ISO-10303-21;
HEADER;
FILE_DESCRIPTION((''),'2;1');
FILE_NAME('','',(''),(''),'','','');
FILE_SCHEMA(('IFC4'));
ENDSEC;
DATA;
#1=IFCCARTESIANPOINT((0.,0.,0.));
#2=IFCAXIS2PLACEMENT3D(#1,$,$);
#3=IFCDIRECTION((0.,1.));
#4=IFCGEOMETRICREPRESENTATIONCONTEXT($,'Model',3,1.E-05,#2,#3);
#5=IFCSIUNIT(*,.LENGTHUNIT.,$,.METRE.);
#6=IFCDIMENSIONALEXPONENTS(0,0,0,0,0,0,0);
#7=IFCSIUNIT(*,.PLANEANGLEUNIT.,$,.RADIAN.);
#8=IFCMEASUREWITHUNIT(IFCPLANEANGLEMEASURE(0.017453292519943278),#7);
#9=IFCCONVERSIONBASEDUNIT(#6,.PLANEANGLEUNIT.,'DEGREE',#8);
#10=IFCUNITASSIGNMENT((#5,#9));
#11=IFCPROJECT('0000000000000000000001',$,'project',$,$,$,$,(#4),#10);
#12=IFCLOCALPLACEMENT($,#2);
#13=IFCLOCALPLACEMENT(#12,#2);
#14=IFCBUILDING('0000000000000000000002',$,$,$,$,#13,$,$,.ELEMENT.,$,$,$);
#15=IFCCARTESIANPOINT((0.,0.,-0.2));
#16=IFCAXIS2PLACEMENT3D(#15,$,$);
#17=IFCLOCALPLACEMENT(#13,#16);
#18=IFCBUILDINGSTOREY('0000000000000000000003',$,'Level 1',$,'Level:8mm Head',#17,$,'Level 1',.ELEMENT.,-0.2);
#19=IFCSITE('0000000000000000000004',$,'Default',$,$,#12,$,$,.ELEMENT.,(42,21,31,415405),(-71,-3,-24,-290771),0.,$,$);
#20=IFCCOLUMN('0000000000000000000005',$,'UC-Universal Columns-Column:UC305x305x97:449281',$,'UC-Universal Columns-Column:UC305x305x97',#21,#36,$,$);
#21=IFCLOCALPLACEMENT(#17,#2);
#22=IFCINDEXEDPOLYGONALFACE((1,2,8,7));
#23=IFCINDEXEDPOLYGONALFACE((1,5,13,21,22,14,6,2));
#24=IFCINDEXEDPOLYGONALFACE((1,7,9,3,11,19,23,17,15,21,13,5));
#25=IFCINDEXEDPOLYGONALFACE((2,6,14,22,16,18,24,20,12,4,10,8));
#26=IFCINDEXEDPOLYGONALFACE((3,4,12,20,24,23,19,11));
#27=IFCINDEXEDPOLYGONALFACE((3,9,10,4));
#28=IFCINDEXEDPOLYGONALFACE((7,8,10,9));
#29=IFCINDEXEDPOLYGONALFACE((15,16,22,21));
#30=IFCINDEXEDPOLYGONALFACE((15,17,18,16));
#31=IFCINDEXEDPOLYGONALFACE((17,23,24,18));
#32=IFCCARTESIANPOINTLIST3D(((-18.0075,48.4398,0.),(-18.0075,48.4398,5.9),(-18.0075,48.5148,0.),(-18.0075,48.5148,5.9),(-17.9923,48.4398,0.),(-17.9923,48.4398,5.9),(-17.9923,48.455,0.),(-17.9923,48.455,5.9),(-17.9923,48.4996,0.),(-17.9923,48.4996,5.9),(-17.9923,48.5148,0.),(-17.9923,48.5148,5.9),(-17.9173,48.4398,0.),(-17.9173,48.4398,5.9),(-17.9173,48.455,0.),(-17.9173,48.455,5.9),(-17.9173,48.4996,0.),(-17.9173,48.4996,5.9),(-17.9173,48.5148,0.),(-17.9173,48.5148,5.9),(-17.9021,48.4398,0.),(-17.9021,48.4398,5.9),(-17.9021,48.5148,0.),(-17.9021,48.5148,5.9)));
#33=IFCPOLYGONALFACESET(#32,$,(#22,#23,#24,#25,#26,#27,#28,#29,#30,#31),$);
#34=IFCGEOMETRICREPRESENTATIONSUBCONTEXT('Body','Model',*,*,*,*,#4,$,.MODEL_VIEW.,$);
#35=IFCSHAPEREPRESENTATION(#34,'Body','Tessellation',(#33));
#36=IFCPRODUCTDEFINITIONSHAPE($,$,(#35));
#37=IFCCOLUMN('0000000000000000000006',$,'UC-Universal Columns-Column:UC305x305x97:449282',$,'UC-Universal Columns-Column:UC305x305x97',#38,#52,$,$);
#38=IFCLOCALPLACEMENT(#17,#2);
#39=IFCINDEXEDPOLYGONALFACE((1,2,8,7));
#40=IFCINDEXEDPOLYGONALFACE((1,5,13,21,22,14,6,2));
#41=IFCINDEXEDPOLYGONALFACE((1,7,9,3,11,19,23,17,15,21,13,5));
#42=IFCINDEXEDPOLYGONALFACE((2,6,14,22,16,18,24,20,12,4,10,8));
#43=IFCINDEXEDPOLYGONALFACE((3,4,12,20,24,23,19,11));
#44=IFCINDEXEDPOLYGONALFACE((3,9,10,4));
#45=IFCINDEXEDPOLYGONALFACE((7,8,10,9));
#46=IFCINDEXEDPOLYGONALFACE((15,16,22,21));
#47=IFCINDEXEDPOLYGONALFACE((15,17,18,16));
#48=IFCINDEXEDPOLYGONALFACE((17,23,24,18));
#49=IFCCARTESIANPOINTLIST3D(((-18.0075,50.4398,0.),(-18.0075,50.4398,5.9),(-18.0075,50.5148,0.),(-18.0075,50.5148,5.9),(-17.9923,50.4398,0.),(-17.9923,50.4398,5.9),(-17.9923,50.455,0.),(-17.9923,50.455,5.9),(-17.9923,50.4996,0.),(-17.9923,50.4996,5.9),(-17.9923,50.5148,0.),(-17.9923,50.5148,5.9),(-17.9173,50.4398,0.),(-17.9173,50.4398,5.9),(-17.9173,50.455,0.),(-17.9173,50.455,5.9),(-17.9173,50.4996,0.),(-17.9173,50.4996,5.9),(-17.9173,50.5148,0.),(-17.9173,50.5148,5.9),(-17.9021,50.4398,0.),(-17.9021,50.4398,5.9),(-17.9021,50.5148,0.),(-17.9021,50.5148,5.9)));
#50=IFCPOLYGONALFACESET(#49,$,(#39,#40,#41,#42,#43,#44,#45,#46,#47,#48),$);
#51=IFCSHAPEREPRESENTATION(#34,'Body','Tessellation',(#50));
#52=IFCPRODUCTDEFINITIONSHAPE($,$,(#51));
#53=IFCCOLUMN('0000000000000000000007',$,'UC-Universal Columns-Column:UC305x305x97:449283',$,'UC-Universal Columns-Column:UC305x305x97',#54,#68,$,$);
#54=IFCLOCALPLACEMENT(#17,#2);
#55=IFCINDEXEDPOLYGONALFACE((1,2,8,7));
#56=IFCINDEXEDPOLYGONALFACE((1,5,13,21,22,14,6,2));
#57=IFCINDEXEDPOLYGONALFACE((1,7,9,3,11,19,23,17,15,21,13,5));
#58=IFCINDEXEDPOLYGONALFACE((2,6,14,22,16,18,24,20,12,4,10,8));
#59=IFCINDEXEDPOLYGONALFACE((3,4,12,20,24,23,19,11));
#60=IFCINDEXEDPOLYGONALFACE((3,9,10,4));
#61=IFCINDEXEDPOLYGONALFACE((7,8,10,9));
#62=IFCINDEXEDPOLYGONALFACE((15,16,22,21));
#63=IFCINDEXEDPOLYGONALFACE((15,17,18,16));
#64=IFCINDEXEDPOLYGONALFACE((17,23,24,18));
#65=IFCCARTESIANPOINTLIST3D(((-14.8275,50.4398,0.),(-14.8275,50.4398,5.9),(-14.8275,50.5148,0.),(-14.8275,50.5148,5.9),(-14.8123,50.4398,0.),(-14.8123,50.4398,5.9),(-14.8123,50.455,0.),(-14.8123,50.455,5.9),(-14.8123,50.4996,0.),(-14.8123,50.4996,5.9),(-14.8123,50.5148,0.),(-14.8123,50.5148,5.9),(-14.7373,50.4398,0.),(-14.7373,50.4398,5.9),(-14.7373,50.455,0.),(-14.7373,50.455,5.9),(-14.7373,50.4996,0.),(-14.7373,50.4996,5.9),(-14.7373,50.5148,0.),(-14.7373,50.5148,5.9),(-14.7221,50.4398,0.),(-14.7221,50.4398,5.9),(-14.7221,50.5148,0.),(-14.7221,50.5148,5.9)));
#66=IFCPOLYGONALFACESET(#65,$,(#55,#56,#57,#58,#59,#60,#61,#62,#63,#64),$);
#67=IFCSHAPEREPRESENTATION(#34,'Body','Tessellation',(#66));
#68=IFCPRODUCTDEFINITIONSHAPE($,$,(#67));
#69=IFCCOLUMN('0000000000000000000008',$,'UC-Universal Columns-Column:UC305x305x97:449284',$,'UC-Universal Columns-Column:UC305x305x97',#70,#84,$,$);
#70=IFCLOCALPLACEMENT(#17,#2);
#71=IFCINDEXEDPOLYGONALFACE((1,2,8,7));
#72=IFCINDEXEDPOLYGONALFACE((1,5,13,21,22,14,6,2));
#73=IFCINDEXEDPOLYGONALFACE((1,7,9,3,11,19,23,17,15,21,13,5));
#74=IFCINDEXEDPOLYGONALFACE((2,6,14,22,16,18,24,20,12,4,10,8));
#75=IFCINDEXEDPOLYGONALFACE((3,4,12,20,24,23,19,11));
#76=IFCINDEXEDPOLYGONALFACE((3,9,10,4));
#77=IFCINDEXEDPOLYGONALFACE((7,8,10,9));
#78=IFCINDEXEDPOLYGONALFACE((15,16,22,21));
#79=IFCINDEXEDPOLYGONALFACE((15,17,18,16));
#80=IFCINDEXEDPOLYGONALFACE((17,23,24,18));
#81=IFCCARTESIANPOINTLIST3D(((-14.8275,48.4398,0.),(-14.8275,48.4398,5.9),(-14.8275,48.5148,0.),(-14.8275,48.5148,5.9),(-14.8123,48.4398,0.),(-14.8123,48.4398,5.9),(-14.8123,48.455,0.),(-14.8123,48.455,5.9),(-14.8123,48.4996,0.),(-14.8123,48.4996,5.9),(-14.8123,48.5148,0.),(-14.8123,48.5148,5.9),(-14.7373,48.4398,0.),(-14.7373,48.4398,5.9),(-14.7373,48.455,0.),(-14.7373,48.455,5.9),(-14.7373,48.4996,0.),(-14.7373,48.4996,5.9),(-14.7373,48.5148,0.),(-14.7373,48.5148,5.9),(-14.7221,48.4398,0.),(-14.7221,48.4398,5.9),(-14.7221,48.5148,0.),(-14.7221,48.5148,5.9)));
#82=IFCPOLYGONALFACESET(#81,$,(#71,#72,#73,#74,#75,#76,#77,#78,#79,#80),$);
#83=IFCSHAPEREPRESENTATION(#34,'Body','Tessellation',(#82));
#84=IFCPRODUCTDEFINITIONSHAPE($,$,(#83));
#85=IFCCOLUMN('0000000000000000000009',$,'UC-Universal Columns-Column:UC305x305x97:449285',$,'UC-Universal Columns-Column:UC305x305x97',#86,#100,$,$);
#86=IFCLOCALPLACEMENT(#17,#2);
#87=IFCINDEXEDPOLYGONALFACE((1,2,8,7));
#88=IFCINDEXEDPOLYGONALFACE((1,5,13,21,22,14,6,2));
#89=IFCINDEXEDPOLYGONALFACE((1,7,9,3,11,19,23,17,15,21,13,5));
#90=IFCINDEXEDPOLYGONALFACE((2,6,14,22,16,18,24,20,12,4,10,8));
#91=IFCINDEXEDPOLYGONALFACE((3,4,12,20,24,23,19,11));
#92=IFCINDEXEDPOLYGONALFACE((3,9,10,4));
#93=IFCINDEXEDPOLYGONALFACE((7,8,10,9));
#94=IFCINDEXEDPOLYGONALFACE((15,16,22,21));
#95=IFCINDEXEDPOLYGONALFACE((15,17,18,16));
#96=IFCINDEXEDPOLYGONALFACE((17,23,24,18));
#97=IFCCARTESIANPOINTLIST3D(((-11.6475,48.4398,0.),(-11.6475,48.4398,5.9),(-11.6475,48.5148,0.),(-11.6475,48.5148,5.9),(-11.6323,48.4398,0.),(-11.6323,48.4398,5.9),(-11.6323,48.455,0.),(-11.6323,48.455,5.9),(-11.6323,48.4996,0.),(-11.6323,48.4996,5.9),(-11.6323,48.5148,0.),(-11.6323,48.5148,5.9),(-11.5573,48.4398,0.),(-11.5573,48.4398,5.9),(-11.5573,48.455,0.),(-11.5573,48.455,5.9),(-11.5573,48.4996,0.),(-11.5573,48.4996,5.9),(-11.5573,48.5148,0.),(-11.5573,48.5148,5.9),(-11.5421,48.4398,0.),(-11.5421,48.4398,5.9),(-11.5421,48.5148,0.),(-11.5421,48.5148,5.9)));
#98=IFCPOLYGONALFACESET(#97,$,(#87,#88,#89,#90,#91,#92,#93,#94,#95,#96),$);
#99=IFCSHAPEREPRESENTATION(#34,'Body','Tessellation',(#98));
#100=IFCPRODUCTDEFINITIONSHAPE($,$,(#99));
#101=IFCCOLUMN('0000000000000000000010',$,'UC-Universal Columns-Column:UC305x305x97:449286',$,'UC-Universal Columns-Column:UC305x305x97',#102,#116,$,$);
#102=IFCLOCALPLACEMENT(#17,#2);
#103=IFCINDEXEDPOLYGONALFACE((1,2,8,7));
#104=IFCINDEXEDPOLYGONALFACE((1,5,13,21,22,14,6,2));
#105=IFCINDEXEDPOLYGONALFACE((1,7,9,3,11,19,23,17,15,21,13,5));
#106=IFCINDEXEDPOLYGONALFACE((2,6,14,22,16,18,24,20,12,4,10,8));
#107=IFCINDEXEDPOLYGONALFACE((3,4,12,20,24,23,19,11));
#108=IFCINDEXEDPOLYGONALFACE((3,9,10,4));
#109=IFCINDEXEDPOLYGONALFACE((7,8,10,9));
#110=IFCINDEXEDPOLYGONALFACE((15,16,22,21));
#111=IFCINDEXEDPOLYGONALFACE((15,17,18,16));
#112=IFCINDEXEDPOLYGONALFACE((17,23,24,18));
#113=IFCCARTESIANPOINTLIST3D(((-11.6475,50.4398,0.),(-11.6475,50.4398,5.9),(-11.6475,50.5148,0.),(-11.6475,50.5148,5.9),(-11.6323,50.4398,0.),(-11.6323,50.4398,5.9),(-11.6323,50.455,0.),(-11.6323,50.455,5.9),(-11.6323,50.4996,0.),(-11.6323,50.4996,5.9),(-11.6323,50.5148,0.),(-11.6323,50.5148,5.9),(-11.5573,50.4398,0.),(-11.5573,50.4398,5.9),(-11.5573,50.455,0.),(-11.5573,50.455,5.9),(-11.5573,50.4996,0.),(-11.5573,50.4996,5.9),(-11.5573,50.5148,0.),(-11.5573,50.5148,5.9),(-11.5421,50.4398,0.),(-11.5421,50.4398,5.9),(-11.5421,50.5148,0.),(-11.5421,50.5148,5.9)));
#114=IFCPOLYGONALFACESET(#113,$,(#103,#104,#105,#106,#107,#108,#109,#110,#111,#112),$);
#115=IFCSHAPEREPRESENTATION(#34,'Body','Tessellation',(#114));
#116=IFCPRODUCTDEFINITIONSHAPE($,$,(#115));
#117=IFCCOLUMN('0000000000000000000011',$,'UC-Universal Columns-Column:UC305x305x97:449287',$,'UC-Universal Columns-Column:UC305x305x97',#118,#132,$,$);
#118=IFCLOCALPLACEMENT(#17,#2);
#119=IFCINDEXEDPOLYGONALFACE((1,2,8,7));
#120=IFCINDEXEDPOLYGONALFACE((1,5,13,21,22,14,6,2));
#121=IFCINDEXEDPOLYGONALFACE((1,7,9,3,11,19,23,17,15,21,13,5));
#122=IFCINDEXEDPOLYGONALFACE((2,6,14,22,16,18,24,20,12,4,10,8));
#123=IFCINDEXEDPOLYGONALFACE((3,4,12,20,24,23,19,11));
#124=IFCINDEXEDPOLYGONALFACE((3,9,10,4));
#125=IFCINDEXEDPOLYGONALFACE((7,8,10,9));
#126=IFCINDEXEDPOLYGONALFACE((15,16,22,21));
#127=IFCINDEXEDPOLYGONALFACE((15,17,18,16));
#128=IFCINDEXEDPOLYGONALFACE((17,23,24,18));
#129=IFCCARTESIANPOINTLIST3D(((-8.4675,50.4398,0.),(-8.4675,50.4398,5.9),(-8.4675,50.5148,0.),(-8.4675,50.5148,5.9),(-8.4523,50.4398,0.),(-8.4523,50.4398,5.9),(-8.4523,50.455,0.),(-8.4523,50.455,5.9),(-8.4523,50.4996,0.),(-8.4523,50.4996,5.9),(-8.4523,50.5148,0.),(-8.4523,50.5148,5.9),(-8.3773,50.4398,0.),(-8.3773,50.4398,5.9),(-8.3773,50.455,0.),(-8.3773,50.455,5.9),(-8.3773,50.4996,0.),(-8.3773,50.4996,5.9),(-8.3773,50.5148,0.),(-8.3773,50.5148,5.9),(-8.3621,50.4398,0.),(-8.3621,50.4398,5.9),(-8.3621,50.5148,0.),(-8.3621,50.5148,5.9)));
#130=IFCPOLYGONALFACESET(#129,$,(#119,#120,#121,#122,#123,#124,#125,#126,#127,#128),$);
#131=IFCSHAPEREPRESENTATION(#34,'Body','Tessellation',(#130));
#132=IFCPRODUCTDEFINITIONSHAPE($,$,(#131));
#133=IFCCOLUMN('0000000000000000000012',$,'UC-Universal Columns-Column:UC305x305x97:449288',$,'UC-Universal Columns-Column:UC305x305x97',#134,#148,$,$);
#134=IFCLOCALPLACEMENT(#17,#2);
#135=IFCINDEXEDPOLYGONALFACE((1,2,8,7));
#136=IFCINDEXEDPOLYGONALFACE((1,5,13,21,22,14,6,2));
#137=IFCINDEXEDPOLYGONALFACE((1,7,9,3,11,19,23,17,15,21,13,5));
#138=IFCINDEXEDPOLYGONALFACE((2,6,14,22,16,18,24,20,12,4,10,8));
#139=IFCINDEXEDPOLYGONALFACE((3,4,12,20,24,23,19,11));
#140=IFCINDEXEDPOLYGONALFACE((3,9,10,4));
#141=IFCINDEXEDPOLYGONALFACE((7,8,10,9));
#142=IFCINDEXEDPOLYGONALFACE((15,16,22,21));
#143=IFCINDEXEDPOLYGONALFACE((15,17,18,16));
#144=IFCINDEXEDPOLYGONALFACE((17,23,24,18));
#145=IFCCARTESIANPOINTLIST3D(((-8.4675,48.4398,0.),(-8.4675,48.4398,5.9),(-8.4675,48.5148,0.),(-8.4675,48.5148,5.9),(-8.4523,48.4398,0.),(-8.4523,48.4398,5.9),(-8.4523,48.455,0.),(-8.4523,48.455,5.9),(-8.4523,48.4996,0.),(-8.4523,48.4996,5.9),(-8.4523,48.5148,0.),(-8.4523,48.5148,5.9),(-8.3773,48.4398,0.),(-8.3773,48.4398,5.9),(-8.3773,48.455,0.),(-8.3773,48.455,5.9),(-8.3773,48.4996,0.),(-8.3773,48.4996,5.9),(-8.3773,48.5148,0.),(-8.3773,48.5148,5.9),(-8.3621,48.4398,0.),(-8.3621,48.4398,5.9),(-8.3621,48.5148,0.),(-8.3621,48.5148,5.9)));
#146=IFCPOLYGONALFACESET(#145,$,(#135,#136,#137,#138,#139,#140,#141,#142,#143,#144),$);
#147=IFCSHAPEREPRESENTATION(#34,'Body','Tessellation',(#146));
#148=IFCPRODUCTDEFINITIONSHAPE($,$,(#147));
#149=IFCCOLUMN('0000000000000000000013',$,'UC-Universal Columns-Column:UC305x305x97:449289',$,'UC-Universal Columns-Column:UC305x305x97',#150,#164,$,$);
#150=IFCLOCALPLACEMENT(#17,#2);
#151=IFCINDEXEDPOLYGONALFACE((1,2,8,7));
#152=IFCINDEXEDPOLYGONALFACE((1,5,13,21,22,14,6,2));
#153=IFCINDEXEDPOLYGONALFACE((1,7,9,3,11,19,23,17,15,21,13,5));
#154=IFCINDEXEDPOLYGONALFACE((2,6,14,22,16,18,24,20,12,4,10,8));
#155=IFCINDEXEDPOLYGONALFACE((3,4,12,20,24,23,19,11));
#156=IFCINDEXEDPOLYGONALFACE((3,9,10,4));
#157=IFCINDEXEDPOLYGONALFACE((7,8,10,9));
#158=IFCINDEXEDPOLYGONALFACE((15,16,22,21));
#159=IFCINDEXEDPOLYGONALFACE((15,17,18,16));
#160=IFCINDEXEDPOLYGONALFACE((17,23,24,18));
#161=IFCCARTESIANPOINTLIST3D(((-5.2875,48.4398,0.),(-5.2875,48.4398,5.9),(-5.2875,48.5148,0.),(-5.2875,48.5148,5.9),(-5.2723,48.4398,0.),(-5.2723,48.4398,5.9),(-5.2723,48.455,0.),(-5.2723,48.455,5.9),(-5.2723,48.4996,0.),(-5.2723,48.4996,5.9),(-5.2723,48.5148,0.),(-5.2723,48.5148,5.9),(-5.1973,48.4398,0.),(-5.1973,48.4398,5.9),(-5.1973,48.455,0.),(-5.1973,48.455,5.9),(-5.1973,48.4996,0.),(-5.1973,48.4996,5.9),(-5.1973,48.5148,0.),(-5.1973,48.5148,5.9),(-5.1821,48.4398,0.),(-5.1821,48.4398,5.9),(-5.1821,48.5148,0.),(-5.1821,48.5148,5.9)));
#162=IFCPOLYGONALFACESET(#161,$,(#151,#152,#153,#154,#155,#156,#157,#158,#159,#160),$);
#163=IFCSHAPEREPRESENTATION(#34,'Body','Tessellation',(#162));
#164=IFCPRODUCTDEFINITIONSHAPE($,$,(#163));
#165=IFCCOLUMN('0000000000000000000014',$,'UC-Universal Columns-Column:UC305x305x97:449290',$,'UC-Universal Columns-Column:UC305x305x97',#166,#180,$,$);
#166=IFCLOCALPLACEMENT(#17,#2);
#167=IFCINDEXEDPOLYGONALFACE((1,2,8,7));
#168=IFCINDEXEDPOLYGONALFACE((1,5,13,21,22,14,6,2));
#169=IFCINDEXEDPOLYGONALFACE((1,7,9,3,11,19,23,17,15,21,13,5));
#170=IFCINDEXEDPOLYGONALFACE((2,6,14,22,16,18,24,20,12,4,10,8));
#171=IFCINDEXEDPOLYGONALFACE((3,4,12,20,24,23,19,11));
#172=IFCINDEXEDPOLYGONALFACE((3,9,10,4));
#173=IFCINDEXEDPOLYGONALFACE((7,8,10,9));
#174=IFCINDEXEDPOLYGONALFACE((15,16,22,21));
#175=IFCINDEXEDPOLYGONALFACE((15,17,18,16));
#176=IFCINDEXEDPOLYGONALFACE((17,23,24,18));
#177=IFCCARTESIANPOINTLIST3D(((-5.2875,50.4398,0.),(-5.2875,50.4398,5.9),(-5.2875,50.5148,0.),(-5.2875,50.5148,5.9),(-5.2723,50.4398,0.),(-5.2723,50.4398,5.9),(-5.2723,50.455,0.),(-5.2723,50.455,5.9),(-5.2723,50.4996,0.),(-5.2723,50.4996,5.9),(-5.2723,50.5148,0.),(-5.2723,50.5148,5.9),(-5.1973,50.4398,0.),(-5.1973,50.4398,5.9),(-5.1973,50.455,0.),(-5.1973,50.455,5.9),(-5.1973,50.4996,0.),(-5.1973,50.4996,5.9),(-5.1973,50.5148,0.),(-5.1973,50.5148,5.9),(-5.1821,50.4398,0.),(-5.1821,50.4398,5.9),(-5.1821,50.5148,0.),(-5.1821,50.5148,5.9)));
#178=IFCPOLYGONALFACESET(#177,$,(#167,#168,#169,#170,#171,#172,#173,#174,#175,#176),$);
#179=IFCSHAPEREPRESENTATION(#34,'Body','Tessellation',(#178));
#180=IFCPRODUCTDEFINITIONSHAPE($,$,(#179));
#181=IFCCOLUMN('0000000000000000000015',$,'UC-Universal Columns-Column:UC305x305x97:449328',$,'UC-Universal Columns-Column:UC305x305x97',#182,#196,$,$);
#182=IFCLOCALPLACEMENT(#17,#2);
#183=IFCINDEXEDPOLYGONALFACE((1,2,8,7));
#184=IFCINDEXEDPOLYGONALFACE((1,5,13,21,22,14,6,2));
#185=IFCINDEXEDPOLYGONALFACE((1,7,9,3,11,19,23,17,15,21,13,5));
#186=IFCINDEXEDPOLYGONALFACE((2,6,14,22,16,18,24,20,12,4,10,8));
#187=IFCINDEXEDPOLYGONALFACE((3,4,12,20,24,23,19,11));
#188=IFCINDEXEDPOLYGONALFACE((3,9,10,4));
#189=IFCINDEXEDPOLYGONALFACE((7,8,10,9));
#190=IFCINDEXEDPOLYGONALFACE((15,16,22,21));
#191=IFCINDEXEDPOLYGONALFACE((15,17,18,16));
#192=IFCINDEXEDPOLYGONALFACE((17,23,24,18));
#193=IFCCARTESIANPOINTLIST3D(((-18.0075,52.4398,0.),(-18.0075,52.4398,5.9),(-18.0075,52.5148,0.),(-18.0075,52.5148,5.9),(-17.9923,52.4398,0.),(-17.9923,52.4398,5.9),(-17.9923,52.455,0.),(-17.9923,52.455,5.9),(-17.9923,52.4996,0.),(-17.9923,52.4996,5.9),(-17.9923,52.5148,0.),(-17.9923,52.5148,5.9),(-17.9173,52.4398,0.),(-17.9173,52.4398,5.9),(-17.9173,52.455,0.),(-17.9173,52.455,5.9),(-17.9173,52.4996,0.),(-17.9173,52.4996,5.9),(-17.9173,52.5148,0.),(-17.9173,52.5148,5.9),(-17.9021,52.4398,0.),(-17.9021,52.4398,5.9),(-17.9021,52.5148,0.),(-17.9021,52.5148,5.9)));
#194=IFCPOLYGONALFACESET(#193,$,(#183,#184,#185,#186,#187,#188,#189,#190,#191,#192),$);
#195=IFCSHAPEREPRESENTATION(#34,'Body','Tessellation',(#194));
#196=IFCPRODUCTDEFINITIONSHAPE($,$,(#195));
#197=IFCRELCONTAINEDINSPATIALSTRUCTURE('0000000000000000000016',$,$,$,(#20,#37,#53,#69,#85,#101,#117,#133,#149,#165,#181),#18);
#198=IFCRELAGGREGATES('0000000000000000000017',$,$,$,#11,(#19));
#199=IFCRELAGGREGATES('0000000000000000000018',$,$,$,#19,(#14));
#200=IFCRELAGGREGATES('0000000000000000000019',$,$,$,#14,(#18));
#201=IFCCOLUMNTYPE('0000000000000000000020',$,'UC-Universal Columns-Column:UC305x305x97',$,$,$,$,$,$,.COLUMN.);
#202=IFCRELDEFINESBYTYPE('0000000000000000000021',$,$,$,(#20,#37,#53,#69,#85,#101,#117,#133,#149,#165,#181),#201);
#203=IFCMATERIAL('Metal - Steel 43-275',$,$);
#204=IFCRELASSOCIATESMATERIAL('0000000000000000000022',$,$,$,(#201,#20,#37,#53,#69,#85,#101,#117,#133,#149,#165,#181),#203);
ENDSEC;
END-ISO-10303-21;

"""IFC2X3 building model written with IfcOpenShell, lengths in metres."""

from ifc_helpers import new_model, entity, si_unit, converted_unit, direction, frame, frame_2d, origin, place, context, subcontext, project, spatial, polyline, circle_curve, parameter, trimmed, segment, composite_curve, outline, extrude, source, transform, mapped, material, type_object, type_shapes, element, save


model = new_model("IFC2X3")

# Units and contexts
model_context = context("Model", 3, precision=1e-05, world=origin(), true_north=direction((0.0, 1.0)))
body_context = subcontext(model_context, "Body", "Model", "MODEL_VIEW")
ifc_project = project(units=[si_unit("LENGTHUNIT", "METRE"), converted_unit("PLANEANGLEUNIT", "DEGREE", entity("IfcPlaneAngleMeasure", 0.017453292519943278), si_unit("PLANEANGLEUNIT", "RADIAN"), dimensions=[0, 0, 0, 0, 0, 0, 0])], contexts=[model_context])

# Site, building, storey
site_placement = place(None, origin())
site = spatial("IfcSite", under=ifc_project, at=site_placement, Name="Default", CompositionType="ELEMENT", RefLatitude=(42, 21, 31, 415405), RefLongitude=(-71, -3, -24, -290771), RefElevation=0.0)
building_placement = place(site_placement, origin())
building = spatial("IfcBuilding", under=site, at=building_placement, CompositionType="ELEMENT")
storey_placement = place(building_placement, frame((0.0, 0.0, -0.2)))
storey = spatial("IfcBuildingStorey", under=building, at=storey_placement, Name="Level 1", ObjectType="Level:8mm Head", LongName="Level 1", CompositionType="ELEMENT", Elevation=-0.2)

# Columns
ifc_material = material(Name="Metal - Steel 43-275")
column_type = type_object("IfcColumnType", Name="UC-Universal Columns-Column:UC305x305x97", PredefinedType="COLUMN", material=ifc_material)
shared_shape = source(origin(), body_context, "Body", "SweptSolid", [
    extrude(outline(composite_curve([segment(polyline([(-0.0375, -0.0375), (0.0375, -0.0375)]), True, "CONTINUOUS"), segment(polyline([(0.0375, -0.0375), (0.0527, -0.0375)]), True, "CONTINUOUS"), segment(trimmed(circle_curve(frame_2d((0.0527, -0.0223), x_axis=(-1.0, 0.0)), 0.0152), [parameter(0.0)], [parameter(90.0)], True, "PARAMETER"), False, "CONTINUOUS"), segment(polyline([(0.0375, -0.0223), (0.0375, 0.0223)]), True, "CONTINUOUS"), segment(trimmed(circle_curve(frame_2d((0.0527, 0.0223), x_axis=(-1.0, 0.0)), 0.0152), [parameter(270.0)], [parameter(0.0)], True, "PARAMETER"), False, "CONTINUOUS"), segment(polyline([(0.0527, 0.0375), (0.0375, 0.0375)]), True, "CONTINUOUS"), segment(polyline([(0.0375, 0.0375), (-0.0375, 0.0375)]), True, "CONTINUOUS"), segment(polyline([(-0.0375, 0.0375), (-0.0527, 0.0375)]), True, "CONTINUOUS"), segment(trimmed(circle_curve(frame_2d((-0.0527, 0.0223), x_axis=(-1.0, 0.0)), 0.0152), [parameter(180.0)], [parameter(270.0)], True, "PARAMETER"), False, "CONTINUOUS"), segment(polyline([(-0.0375, 0.0223), (-0.0375, -0.0223)]), True, "CONTINUOUS"), segment(trimmed(circle_curve(frame_2d((-0.0527, -0.0223), x_axis=(-1.0, 0.0)), 0.0152), [parameter(90.0)], [parameter(180.0)], True, "PARAMETER"), False, "CONTINUOUS"), segment(polyline([(-0.0527, -0.0375), (-0.0375, -0.0375)]), True, "CONTINUOUS")], self_intersect=False)), frame((0.0, 0.0, -0.2), z_axis=(0.0, 0.0, 1.0), x_axis=(-1.0, 0.0, 0.0)), (0.0, 0.0, 1.0), 5.9),
])
type_shapes(column_type, [shared_shape])
for number, where, z_axis, x_axis, name in (
    (1, (-17.9548, 48.4773, 0.2), (0.0, 0.0, 1.0), (-1.0, 0.0, 0.0), "UC-Universal Columns-Column:UC305x305x97:449281"),
    (2, (-17.9548, 50.4773, 0.2), (0.0, 0.0, 1.0), (-1.0, 0.0, 0.0), "UC-Universal Columns-Column:UC305x305x97:449282"),
    (3, (-14.7748, 50.4773, 0.2), (0.0, 0.0, 1.0), (-1.0, 0.0, 0.0), "UC-Universal Columns-Column:UC305x305x97:449283"),
    (4, (-14.7748, 48.4773, 0.2), (0.0, 0.0, 1.0), (-1.0, 0.0, 0.0), "UC-Universal Columns-Column:UC305x305x97:449284"),
    (5, (-11.5948, 48.4773, 0.2), (0.0, 0.0, 1.0), (-1.0, 0.0, 0.0), "UC-Universal Columns-Column:UC305x305x97:449285"),
    (6, (-11.5948, 50.4773, 0.2), (0.0, 0.0, 1.0), (-1.0, 0.0, 0.0), "UC-Universal Columns-Column:UC305x305x97:449286"),
    (7, (-8.4148, 50.4773, 0.2), (0.0, 0.0, 1.0), (-1.0, 0.0, 0.0), "UC-Universal Columns-Column:UC305x305x97:449287"),
    (8, (-8.4148, 48.4773, 0.2), (0.0, 0.0, 1.0), (-1.0, 0.0, 0.0), "UC-Universal Columns-Column:UC305x305x97:449288"),
    (9, (-5.2348, 48.4773, 0.2), (0.0, 0.0, 1.0), (-1.0, 0.0, 0.0), "UC-Universal Columns-Column:UC305x305x97:449289"),
    (10, (-5.2348, 50.4773, 0.2), (0.0, 0.0, 1.0), (-1.0, 0.0, 0.0), "UC-Universal Columns-Column:UC305x305x97:449290"),
    (11, (-17.9548, 52.4773, 0.2), (0.0, 0.0, 1.0), (-1.0, 0.0, 0.0), "UC-Universal Columns-Column:UC305x305x97:449328"),
):
    element("IfcColumn", number, at=place(storey_placement, frame(where, z_axis=z_axis, x_axis=x_axis)), inside=storey, type_object=column_type, material=ifc_material, Name=name, ObjectType="UC-Universal Columns-Column:UC305x305x97", context=body_context, shape_type="MappedRepresentation", body=[
        mapped(shared_shape, transform((0.0, 0.0, 0.0), scale=1.0)),
    ])

save(model, "model.ifc")
